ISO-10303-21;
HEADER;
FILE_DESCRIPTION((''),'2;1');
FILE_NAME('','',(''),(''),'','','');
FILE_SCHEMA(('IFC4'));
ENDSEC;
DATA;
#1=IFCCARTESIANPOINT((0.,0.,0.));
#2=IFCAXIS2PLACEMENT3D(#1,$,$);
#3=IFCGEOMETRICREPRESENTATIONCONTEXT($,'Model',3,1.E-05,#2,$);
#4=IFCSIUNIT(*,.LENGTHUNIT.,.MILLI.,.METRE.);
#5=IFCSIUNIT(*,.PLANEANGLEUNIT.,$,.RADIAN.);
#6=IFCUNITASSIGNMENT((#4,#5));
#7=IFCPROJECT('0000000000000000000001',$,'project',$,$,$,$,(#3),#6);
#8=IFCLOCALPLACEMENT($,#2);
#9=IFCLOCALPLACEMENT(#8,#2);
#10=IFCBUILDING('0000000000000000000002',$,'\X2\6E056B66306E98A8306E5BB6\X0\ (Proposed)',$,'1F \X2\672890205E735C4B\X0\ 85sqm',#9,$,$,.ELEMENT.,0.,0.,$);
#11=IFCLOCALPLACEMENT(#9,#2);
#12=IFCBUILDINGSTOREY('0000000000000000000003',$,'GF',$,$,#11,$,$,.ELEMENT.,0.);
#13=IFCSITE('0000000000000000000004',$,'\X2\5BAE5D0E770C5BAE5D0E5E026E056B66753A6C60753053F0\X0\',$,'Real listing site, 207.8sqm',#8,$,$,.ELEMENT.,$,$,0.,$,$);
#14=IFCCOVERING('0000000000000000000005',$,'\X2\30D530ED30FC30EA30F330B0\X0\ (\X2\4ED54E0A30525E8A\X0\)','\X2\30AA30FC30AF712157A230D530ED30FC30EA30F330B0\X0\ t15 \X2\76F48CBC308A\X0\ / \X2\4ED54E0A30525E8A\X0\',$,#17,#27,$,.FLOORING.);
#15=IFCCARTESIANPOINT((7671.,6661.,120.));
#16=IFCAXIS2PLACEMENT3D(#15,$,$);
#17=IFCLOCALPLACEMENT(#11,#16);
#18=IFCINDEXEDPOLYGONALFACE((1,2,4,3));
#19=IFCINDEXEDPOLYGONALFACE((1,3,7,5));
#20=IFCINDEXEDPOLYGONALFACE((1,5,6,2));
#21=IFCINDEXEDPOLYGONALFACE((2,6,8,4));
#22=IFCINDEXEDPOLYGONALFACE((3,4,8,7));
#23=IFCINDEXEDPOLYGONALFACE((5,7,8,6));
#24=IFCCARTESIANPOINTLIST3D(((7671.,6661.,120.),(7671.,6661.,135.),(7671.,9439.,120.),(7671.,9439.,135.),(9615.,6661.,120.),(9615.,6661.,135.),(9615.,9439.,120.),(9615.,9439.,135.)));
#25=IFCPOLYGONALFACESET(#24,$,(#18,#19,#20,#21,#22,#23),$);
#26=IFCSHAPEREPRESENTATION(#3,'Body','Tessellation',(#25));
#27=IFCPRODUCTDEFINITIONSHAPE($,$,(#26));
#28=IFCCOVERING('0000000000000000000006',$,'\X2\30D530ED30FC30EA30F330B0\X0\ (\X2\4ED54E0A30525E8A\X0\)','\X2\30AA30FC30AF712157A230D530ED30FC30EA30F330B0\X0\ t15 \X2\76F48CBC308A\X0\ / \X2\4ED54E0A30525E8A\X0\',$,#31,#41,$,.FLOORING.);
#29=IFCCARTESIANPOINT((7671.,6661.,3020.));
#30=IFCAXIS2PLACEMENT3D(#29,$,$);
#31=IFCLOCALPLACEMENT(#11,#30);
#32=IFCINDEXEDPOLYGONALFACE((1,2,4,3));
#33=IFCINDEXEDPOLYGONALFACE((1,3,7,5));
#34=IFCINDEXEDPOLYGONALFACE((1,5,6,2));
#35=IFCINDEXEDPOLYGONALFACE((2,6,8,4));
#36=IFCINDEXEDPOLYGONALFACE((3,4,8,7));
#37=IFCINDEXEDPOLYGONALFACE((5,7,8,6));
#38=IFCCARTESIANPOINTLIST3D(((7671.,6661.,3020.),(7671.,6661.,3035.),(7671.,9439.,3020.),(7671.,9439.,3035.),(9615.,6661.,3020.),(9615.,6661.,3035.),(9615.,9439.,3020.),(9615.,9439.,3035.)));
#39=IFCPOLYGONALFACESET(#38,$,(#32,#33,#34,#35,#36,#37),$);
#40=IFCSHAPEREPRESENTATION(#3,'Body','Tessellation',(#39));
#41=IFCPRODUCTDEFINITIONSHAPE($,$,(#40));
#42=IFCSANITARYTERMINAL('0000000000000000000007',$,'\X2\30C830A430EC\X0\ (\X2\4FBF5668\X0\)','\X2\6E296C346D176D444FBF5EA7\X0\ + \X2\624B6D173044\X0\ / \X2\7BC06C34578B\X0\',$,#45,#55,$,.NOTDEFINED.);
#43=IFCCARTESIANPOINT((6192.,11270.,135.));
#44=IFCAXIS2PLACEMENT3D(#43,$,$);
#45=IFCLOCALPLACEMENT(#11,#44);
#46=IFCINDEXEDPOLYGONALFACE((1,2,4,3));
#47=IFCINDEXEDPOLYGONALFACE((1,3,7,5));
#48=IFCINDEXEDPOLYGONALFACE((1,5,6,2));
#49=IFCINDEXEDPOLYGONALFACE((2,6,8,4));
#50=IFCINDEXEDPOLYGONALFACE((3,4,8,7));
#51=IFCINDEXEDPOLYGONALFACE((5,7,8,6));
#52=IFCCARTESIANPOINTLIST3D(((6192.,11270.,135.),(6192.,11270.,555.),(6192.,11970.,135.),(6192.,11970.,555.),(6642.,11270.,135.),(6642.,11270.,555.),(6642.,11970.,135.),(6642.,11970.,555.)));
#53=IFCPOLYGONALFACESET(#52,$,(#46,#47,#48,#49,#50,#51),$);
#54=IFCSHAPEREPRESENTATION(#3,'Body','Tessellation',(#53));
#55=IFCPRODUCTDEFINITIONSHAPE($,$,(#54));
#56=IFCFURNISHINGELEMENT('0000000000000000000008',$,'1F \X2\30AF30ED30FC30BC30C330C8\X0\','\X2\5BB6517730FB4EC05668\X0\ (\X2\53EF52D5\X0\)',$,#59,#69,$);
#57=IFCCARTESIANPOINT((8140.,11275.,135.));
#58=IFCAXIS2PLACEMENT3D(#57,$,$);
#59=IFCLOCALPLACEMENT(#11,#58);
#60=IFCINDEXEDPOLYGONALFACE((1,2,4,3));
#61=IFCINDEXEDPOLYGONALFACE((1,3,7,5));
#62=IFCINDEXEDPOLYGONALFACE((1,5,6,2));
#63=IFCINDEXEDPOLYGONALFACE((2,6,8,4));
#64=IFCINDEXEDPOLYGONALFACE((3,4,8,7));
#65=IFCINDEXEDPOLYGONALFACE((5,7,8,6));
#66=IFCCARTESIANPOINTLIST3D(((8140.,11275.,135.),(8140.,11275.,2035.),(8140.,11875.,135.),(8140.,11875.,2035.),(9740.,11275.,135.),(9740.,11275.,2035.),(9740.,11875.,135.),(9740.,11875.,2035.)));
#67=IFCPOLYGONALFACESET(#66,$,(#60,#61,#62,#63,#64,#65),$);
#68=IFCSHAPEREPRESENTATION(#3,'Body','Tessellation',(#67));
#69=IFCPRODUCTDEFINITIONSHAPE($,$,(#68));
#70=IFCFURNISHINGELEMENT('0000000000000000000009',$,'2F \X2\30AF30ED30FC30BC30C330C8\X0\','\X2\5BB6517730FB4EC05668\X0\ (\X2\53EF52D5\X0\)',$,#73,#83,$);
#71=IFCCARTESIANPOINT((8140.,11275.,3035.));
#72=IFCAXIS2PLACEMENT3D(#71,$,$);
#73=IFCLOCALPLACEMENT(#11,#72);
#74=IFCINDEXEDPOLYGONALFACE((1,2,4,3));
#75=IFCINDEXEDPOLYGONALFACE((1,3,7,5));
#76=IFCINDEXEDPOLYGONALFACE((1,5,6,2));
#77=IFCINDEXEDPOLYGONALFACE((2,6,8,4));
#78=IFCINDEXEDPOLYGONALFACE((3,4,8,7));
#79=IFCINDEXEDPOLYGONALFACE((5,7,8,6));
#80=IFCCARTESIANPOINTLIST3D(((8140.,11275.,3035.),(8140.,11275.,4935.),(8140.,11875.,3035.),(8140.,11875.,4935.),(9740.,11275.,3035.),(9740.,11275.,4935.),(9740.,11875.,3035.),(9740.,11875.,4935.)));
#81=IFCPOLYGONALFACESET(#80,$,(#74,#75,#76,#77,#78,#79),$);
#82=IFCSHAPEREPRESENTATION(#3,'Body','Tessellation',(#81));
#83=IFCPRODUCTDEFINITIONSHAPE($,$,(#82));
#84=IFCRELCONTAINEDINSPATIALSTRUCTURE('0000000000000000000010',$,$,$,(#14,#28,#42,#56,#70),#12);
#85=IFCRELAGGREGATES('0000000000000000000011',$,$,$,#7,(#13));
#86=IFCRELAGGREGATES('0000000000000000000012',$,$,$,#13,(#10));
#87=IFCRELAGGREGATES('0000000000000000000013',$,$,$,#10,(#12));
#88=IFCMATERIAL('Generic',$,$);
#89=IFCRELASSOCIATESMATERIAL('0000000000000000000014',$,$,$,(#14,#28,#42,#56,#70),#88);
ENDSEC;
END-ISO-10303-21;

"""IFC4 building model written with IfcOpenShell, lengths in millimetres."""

from ifc_helpers import new_model, si_unit, frame, frame_2d, origin, place, context, project, spatial, rectangle, extrude, material, element, save


model = new_model("IFC4")

# Units and contexts
model_context = context("Model", 3, precision=1e-05, world=origin())
ifc_project = project(units=[si_unit("LENGTHUNIT", "METRE", prefix="MILLI"), si_unit("PLANEANGLEUNIT", "RADIAN")], contexts=[model_context])

# Site, building, storey
site_placement = place(None, origin())
site = spatial("IfcSite", under=ifc_project, at=site_placement, Name="宮崎県宮崎市清武町池田台", ObjectType="Real listing site, 207.8sqm", CompositionType="ELEMENT", RefElevation=0.0)
building_placement = place(site_placement, origin())
building = spatial("IfcBuilding", under=site, at=building_placement, Name="清武の風の家 (Proposed)", ObjectType="1F 木造平屋 85sqm", CompositionType="ELEMENT", ElevationOfRefHeight=0.0, ElevationOfTerrain=0.0)
storey_placement = place(building_placement, origin())
storey = spatial("IfcBuildingStorey", under=building, at=storey_placement, Name="GF", CompositionType="ELEMENT", Elevation=0.0)

# Shared definitions
ifc_material_1 = material(Name="Generic")

# Coverings
covering_1_placement = place(storey_placement, frame((7671.0, 6661.0, 120.0)))
element("IfcCovering", 1, at=covering_1_placement, inside=storey, material=ifc_material_1, Name="フローリング (仕上げ床)", Description="オーク無垢フローリング t15 直貼り / 仕上げ床", PredefinedType="FLOORING", context=model_context, shape_type="SweptSolid", body=[
    extrude(rectangle(XDim=1944.0, YDim=2778.0, at=frame_2d((972.0, 1389.0))), frame((7671.0, 6661.0, 120.0)), (0.0, 0.0, 1.0), 15.0),
])
covering_2_placement = place(storey_placement, frame((7671.0, 6661.0, 3020.0)))
element("IfcCovering", 2, at=covering_2_placement, inside=storey, material=ifc_material_1, Name="フローリング (仕上げ床)", Description="オーク無垢フローリング t15 直貼り / 仕上げ床", PredefinedType="FLOORING", context=model_context, shape_type="SweptSolid", body=[
    extrude(rectangle(XDim=1944.0, YDim=2778.0, at=frame_2d((972.0, 1389.0))), frame((7671.0, 6661.0, 3020.0)), (0.0, 0.0, 1.0), 15.0),
])

# Sanitary terminal
sanitary_terminal_placement = place(storey_placement, frame((6192.0, 11270.0, 135.0)))
element("IfcSanitaryTerminal", 3, at=sanitary_terminal_placement, inside=storey, material=ifc_material_1, Name="トイレ (便器)", Description="温水洗浄便座 + 手洗い / 節水型", PredefinedType="NOTDEFINED", context=model_context, shape_type="SweptSolid", body=[
    extrude(rectangle(XDim=450.0, YDim=700.0, at=frame_2d((225.0, 350.0))), frame((6192.0, 11270.0, 135.0)), (0.0, 0.0, 1.0), 420.0),
])

# Furnishing elements
furnishing_1_placement = place(storey_placement, frame((8140.0, 11275.0, 135.0)))
element("IfcFurnishingElement", 4, at=furnishing_1_placement, inside=storey, material=ifc_material_1, Name="1F クローゼット", Description="家具・什器 (可動)", context=model_context, shape_type="SweptSolid", body=[
    extrude(rectangle(XDim=1600.0, YDim=600.0, at=frame_2d((800.0, 300.0))), frame((8140.0, 11275.0, 135.0)), (0.0, 0.0, 1.0), 1900.0),
])
furnishing_2_placement = place(storey_placement, frame((8140.0, 11275.0, 3035.0)))
element("IfcFurnishingElement", 5, at=furnishing_2_placement, inside=storey, material=ifc_material_1, Name="2F クローゼット", Description="家具・什器 (可動)", context=model_context, shape_type="SweptSolid", body=[
    extrude(rectangle(XDim=1600.0, YDim=600.0, at=frame_2d((800.0, 300.0))), frame((8140.0, 11275.0, 3035.0)), (0.0, 0.0, 1.0), 1900.0),
])

save(model, "model.ifc")
